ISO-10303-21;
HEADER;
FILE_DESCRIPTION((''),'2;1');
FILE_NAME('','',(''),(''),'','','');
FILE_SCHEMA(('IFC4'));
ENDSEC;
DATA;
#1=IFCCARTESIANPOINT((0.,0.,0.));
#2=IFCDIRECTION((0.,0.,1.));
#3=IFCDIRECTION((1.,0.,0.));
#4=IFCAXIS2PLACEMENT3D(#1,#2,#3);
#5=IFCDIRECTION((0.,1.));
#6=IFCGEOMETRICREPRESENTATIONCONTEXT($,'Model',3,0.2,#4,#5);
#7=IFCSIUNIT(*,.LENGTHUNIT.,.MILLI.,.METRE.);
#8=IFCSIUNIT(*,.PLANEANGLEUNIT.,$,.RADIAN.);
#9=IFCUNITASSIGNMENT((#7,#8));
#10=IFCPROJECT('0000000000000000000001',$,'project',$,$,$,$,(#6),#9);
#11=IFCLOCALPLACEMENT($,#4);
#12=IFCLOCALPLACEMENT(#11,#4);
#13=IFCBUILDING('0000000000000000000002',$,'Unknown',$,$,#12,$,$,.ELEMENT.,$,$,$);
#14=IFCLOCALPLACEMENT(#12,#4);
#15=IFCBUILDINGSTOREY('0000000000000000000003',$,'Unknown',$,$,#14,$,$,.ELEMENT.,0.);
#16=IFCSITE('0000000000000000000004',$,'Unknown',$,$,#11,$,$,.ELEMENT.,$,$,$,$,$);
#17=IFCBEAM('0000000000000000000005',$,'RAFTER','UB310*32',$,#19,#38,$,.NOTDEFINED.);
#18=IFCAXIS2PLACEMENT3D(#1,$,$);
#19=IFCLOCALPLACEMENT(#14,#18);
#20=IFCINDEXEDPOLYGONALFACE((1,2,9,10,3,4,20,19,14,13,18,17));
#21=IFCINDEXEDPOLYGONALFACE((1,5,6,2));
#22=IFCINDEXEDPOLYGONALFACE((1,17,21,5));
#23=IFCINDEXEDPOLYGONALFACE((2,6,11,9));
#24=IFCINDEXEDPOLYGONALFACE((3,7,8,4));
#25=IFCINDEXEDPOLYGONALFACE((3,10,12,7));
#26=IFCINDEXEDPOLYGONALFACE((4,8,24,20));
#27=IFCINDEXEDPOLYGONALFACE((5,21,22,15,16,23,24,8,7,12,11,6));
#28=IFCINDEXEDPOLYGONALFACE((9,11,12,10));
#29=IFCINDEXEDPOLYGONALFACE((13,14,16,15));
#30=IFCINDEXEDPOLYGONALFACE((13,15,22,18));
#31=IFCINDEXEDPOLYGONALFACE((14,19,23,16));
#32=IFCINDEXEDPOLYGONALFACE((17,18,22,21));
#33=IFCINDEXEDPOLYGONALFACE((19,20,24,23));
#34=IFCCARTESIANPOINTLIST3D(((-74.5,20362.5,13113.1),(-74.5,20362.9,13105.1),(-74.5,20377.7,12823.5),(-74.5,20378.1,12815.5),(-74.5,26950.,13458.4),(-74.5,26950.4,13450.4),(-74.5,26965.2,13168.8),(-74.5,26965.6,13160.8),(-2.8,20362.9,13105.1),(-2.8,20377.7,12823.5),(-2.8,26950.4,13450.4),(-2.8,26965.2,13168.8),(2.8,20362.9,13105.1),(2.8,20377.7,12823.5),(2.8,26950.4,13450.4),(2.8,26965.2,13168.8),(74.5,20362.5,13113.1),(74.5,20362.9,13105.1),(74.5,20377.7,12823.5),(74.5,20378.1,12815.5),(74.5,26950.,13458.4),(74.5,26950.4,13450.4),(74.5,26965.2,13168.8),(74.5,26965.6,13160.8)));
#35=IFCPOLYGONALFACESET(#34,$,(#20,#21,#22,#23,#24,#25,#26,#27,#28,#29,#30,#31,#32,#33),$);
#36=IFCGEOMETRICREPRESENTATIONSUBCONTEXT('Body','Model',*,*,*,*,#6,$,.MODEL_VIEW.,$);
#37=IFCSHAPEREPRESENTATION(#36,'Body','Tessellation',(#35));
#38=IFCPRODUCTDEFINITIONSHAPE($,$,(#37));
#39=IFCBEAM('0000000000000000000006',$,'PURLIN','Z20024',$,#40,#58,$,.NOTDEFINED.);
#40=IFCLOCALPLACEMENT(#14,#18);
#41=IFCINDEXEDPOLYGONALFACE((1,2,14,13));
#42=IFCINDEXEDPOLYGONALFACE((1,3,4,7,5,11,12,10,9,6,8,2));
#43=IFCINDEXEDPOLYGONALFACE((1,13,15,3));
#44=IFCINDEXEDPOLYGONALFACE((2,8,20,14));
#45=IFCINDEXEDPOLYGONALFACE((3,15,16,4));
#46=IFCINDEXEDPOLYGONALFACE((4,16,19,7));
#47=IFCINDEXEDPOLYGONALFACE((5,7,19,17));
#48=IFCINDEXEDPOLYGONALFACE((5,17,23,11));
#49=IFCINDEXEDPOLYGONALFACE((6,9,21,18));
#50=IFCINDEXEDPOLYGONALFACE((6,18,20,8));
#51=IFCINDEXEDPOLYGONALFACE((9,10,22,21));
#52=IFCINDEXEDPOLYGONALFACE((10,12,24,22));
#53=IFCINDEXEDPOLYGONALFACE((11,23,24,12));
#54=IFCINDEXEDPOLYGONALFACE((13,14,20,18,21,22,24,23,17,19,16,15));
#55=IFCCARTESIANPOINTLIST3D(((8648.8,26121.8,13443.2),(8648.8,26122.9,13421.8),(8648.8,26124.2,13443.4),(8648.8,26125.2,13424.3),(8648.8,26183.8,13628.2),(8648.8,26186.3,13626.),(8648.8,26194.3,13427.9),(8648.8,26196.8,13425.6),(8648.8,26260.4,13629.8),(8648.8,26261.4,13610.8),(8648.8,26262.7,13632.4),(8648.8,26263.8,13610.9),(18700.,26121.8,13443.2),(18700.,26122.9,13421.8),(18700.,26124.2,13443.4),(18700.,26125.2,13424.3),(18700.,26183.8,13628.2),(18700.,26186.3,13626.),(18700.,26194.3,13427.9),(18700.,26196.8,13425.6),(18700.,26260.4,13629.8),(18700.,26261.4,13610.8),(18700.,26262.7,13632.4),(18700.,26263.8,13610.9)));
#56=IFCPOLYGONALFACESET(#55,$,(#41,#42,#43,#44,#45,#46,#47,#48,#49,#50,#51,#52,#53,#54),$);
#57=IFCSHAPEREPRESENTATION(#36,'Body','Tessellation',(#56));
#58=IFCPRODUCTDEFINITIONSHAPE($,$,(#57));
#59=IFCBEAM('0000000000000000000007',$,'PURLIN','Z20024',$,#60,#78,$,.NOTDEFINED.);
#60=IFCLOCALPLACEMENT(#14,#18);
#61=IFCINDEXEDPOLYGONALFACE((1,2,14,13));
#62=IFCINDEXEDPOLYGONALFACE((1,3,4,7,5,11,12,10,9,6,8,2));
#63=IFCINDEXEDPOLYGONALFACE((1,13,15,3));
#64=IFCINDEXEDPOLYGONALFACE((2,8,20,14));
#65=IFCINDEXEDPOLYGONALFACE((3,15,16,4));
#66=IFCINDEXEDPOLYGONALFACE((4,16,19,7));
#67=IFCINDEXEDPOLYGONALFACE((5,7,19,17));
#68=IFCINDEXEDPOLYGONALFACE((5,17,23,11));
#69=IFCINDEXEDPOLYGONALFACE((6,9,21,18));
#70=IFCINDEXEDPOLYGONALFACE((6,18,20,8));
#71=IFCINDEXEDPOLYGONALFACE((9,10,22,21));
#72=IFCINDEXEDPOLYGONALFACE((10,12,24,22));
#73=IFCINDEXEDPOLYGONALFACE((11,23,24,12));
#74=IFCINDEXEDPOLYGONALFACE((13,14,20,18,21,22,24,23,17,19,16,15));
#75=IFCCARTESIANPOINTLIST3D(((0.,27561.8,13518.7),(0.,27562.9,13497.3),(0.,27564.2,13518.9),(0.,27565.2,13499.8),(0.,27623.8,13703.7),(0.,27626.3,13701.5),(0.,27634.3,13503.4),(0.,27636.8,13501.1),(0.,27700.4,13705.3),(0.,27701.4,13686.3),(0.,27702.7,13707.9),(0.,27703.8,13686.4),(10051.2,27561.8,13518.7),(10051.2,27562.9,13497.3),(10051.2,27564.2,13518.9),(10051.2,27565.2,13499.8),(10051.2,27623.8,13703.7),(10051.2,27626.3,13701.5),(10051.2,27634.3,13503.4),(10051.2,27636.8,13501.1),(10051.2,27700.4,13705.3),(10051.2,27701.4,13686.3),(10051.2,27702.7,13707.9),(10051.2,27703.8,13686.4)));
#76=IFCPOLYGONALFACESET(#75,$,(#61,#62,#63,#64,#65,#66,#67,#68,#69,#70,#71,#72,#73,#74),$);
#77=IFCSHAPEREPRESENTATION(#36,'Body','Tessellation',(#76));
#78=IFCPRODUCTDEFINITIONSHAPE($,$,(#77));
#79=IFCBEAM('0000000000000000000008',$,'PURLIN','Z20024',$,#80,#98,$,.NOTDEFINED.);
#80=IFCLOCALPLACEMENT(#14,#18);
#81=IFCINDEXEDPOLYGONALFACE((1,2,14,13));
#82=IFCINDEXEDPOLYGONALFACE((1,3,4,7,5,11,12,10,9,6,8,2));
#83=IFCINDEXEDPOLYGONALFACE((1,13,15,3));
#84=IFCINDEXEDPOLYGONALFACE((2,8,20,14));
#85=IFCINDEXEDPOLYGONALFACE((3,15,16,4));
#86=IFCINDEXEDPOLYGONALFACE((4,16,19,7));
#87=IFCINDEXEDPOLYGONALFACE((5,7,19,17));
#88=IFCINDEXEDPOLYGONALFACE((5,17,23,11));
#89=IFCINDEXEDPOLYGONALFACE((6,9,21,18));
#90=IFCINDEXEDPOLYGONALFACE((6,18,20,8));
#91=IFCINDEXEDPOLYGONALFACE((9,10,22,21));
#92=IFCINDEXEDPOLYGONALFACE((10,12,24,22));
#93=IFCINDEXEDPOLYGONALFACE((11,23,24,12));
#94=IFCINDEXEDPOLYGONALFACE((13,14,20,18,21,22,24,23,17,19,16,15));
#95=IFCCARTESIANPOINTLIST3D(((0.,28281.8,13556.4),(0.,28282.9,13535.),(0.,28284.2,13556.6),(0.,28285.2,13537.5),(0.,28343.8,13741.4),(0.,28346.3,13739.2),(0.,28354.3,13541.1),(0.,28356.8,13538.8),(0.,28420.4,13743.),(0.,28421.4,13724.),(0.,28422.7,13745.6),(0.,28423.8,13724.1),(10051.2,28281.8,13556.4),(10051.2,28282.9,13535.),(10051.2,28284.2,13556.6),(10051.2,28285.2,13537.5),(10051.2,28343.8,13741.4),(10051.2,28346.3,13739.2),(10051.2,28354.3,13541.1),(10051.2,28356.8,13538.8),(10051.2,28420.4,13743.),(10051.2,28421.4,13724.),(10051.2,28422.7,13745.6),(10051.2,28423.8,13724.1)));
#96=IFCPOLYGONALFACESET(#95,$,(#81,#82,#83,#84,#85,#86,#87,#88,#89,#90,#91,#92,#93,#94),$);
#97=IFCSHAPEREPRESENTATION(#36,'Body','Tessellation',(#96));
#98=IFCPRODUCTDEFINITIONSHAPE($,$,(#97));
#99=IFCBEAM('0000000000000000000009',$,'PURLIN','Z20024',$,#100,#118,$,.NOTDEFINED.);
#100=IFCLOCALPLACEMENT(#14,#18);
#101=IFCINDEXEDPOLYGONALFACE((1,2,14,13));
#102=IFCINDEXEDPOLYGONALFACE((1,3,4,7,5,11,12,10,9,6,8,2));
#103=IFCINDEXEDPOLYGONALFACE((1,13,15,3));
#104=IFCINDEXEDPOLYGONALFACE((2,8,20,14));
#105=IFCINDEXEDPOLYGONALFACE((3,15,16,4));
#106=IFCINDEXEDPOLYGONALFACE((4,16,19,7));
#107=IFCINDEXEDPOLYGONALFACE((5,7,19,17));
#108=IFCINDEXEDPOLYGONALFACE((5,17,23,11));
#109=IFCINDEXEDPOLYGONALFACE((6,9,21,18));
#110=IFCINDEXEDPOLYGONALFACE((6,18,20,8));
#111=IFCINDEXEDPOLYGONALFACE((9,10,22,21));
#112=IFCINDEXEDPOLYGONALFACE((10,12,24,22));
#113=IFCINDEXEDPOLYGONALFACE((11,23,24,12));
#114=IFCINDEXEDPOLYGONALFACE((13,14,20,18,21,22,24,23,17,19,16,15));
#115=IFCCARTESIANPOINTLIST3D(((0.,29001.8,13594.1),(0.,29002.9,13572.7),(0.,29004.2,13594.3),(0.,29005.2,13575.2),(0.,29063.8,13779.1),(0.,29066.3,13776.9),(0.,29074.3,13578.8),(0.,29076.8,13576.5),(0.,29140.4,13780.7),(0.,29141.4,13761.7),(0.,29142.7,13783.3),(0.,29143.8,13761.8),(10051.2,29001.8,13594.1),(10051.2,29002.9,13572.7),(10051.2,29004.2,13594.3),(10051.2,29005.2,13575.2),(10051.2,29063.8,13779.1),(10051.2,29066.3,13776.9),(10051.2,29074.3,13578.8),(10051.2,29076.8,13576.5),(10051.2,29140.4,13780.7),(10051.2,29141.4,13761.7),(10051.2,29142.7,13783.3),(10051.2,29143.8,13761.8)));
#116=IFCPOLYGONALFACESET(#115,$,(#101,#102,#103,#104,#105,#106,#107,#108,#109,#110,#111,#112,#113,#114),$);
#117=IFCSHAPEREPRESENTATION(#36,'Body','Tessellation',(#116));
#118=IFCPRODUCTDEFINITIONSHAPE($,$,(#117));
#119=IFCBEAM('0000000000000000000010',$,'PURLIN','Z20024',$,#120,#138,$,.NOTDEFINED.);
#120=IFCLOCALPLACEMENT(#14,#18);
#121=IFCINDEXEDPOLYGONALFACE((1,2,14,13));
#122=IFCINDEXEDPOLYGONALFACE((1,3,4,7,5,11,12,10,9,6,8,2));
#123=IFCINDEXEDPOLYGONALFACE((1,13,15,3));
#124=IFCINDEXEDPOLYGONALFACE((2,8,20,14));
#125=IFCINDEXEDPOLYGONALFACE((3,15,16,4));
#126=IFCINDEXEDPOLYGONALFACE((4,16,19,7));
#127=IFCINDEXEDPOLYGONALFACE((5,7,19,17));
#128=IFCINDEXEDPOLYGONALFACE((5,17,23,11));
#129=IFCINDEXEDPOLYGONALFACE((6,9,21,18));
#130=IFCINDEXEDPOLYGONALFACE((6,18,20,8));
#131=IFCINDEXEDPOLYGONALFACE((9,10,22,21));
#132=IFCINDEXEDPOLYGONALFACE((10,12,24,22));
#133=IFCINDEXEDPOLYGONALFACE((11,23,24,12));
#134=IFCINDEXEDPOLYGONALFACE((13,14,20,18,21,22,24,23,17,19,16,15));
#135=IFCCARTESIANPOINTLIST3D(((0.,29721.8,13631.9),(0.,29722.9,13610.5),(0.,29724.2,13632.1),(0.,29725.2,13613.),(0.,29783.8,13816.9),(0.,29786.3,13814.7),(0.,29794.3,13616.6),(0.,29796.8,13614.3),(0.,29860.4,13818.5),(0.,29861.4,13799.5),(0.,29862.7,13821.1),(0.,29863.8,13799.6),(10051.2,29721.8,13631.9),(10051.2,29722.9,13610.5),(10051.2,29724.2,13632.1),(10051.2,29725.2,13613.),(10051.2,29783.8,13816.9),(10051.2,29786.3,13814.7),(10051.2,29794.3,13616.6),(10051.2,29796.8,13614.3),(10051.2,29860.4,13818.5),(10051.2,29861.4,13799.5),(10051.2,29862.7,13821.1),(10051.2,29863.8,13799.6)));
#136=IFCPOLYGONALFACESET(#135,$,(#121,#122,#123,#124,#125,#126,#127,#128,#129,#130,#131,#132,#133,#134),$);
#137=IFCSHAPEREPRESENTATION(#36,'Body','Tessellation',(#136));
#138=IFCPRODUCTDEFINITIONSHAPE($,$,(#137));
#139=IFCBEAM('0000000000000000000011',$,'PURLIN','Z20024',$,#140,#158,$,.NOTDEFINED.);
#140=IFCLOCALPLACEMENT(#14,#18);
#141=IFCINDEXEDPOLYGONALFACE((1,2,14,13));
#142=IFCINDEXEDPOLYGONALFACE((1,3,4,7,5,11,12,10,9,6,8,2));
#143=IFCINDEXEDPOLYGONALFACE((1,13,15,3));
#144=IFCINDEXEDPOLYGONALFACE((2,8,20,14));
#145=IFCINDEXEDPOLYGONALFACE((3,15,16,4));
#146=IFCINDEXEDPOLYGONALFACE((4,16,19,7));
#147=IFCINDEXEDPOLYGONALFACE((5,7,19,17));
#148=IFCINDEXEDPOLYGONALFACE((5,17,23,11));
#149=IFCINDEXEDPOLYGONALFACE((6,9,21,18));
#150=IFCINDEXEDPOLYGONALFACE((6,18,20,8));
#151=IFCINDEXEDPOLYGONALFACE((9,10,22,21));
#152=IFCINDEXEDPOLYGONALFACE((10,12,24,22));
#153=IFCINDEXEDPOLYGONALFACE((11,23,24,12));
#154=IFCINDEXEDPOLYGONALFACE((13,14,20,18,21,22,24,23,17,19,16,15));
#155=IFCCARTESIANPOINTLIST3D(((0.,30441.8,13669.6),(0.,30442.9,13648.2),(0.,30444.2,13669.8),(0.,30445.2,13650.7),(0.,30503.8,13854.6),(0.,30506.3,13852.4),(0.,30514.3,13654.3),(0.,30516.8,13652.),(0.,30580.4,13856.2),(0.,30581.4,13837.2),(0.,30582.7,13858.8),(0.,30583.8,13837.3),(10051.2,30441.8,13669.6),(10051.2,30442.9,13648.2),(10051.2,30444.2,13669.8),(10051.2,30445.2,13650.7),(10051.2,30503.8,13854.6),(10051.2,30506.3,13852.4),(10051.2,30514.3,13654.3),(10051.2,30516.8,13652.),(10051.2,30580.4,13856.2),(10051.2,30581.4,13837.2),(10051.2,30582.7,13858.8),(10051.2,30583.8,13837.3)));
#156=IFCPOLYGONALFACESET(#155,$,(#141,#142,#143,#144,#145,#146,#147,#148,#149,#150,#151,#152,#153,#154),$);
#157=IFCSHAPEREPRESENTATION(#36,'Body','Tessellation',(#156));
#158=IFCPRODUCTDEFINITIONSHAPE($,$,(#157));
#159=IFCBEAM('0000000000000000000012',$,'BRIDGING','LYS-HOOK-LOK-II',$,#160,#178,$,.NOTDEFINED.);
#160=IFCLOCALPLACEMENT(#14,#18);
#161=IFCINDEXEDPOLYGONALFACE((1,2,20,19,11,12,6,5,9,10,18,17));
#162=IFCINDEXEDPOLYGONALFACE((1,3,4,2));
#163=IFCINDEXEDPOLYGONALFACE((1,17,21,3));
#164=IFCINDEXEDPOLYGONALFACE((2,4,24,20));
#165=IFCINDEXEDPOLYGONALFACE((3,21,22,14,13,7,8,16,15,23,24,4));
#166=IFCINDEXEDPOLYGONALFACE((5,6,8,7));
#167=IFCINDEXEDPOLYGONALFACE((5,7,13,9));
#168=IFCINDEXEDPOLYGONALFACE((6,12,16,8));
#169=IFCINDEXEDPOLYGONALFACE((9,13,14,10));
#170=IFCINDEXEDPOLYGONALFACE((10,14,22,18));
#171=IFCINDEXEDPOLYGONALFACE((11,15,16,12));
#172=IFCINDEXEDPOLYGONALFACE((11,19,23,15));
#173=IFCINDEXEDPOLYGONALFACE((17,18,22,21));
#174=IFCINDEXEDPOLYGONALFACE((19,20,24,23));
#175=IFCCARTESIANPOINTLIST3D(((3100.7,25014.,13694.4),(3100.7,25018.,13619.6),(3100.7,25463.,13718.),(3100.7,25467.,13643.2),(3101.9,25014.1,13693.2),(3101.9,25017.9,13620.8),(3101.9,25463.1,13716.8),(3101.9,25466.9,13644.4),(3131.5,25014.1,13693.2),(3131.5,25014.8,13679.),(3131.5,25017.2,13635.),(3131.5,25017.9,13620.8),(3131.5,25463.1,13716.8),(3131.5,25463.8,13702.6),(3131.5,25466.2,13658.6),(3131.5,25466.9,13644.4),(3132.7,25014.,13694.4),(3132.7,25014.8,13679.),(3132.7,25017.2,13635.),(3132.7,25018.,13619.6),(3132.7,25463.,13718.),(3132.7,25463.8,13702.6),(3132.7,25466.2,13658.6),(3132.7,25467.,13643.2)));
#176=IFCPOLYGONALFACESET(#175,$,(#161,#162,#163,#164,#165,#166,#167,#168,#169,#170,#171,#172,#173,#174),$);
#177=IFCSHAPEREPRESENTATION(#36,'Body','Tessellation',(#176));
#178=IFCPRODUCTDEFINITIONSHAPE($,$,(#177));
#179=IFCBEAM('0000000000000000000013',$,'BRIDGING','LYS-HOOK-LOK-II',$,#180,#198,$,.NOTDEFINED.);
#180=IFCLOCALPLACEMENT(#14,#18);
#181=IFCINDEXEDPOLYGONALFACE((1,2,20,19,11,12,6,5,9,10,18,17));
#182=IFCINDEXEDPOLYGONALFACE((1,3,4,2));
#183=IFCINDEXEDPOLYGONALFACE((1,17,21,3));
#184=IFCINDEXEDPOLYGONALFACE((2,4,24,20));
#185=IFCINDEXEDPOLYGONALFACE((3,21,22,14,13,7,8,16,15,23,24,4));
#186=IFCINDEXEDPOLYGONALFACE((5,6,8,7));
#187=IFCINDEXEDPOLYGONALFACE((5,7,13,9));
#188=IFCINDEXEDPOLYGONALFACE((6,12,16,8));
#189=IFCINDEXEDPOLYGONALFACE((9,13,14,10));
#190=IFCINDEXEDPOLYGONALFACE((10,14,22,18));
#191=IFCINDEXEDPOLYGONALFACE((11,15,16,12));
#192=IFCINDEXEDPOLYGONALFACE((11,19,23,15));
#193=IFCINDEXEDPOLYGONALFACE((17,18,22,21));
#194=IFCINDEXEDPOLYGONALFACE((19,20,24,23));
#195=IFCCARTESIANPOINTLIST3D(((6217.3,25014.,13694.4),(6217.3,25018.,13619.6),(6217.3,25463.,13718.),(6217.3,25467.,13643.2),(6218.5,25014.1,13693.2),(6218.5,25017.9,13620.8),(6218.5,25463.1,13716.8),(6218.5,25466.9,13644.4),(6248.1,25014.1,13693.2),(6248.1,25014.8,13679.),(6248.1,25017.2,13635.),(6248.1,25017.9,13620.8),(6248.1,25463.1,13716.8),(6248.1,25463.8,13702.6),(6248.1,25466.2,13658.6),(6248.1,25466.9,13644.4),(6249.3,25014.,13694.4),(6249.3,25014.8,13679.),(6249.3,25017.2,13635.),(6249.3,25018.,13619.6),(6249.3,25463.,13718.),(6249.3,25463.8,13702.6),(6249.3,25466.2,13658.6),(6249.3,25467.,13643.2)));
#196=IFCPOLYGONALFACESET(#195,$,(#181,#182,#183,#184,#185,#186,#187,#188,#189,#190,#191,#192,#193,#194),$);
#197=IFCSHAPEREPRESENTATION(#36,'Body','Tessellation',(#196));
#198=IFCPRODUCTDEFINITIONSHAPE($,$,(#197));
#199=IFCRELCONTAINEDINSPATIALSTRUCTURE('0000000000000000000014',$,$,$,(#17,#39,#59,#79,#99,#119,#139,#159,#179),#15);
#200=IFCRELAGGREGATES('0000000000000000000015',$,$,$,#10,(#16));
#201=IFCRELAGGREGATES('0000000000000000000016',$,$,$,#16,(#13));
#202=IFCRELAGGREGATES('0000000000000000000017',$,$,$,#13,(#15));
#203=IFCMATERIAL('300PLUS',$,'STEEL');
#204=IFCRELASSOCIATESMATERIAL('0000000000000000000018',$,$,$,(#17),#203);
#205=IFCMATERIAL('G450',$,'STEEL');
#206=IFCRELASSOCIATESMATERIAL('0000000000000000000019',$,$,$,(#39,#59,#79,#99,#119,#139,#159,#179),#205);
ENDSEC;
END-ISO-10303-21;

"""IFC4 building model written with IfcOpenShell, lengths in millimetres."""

from ifc_helpers import new_model, si_unit, direction, frame, origin_with_axes, place, context, subcontext, project, spatial, line, indexed_curve, outline, extrude, material, element, save


model = new_model("IFC4")

# Units and contexts
model_context = context("Model", 3, precision=0.2, world=origin_with_axes(), true_north=direction((0.0, 1.0)))
body_context = subcontext(model_context, "Body", "Model", "MODEL_VIEW")
ifc_project = project(units=[si_unit("LENGTHUNIT", "METRE", prefix="MILLI"), si_unit("PLANEANGLEUNIT", "RADIAN")], contexts=[model_context])

# Site, building, storey
site_placement = place(None, origin_with_axes())
site = spatial("IfcSite", under=ifc_project, at=site_placement, Name="Unknown", CompositionType="ELEMENT")
building_placement = place(site_placement, origin_with_axes())
building = spatial("IfcBuilding", under=site, at=building_placement, Name="Unknown", CompositionType="ELEMENT")
storey_placement = place(building_placement, origin_with_axes())
storey = spatial("IfcBuildingStorey", under=building, at=storey_placement, Name="Unknown", CompositionType="ELEMENT", Elevation=0.0)

# Beams
ifc_material_1 = material(Name="300PLUS", Category="STEEL")
beam_placement = place(storey_placement, frame((0.0, 26957.8, 13309.6), z_axis=(-1.0, 0.0, 0.0), x_axis=(0.0, -0.998629, -0.052346)))
element("IfcBeam", 1, at=beam_placement, inside=storey, material=ifc_material_1, Name="RAFTER", Description="UB310*32", PredefinedType="NOTDEFINED", context=body_context, shape_type="SolidModel", body=[
    extrude(outline(indexed_curve([(-74.5, -149.0), (74.5, -149.0), (74.5, -141.0), (2.8, -141.0), (2.8, 141.0), (74.5, 141.0), (74.5, 149.0), (-74.5, 149.0), (-74.5, 141.0), (-2.8, 141.0), (-2.8, -141.0), (-74.5, -141.0)], segments=[line(1, 2, 3, 4, 5, 6, 7, 8, 9, 10, 11, 12, 1)])), frame((0.0, 0.0, 0.0), z_axis=(-1.0, 0.0, 0.0), x_axis=(0.0, 0.0, 1.0)), (0.0, 0.0, -1.0), 6596.5),
])
ifc_material_2 = material(Name="G450", Category="STEEL")
for number, where, z_axis, x_axis, name in (
    (2, (8648.8, 26190.3, 13526.9), (0.0, -0.99863, -0.052336), (1.0, 0.0, 0.0), "PURLIN"),
    (3, (0.0, 27630.3, 13602.4), (0.0, -0.99863, -0.052336), (1.0, 0.0, 0.0), "PURLIN"),
    (4, (0.0, 28350.3, 13640.1), (0.0, -0.99863, -0.052336), (1.0, 0.0, 0.0), "PURLIN"),
    (5, (0.0, 29070.3, 13677.8), (0.0, -0.99863, -0.052336), (1.0, 0.0, 0.0), "PURLIN"),
    (6, (0.0, 29790.3, 13715.6), (0.0, -0.99863, -0.052336), (1.0, 0.0, 0.0), "PURLIN"),
    (7, (0.0, 30510.3, 13753.3), (0.0, -0.99863, -0.052336), (1.0, 0.0, 0.0), "PURLIN"),
):
    element("IfcBeam", number, at=place(storey_placement, frame(where, z_axis=z_axis, x_axis=x_axis)), inside=storey, material=ifc_material_2, Name=name, Description="Z20024", PredefinedType="NOTDEFINED", context=body_context, shape_type="SolidModel", body=[
        extrude(outline(indexed_curve([(72.8, -101.5), (72.8, -80.0), (70.4, -80.0), (70.4, -99.1), (1.2, -99.1), (1.2, 101.5), (-77.8, 101.5), (-77.8, 80.0), (-75.4, 80.0), (-75.4, 99.1), (-1.2, 99.1), (-1.2, -101.5)], segments=[line(1, 2, 3, 4, 5, 6, 7, 8, 9, 10, 11, 12, 1)])), frame((0.0, 0.0, 0.0), z_axis=(-1.0, 0.0, 0.0), x_axis=(0.0, 0.0, 1.0)), (0.0, 0.0, -1.0), 10051.2),
    ])
for number, where, z_axis, x_axis, name in (
    (8, (3116.7, 25016.0, 13657.0), (1.0, 0.0, 0.0), (0.0, 0.998622, 0.052489), "BRIDGING"),
    (9, (6233.3, 25016.0, 13657.0), (1.0, 0.0, 0.0), (0.0, 0.998622, 0.052489), "BRIDGING"),
):
    element("IfcBeam", number, at=place(storey_placement, frame(where, z_axis=z_axis, x_axis=x_axis)), inside=storey, material=ifc_material_2, Name=name, Description="LYS-HOOK-LOK-II", PredefinedType="NOTDEFINED", context=body_context, shape_type="SolidModel", body=[
        extrude(outline(indexed_curve([(16.0, -37.5), (16.0, -22.0), (14.8, -22.0), (14.8, -36.3), (-14.8, -36.3), (-14.8, 36.3), (14.8, 36.3), (14.8, 22.0), (16.0, 22.0), (16.0, 37.5), (-16.0, 37.5), (-16.0, -37.5)], segments=[line(1, 2, 3, 4, 5, 6, 7, 8, 9, 10, 11, 12, 1)])), frame((0.0, 0.0, 0.0), z_axis=(-1.0, 0.0, 0.0), x_axis=(0.0, 0.0, 1.0)), (0.0, 0.0, -1.0), 449.6),
    ])

save(model, "model.ifc")
